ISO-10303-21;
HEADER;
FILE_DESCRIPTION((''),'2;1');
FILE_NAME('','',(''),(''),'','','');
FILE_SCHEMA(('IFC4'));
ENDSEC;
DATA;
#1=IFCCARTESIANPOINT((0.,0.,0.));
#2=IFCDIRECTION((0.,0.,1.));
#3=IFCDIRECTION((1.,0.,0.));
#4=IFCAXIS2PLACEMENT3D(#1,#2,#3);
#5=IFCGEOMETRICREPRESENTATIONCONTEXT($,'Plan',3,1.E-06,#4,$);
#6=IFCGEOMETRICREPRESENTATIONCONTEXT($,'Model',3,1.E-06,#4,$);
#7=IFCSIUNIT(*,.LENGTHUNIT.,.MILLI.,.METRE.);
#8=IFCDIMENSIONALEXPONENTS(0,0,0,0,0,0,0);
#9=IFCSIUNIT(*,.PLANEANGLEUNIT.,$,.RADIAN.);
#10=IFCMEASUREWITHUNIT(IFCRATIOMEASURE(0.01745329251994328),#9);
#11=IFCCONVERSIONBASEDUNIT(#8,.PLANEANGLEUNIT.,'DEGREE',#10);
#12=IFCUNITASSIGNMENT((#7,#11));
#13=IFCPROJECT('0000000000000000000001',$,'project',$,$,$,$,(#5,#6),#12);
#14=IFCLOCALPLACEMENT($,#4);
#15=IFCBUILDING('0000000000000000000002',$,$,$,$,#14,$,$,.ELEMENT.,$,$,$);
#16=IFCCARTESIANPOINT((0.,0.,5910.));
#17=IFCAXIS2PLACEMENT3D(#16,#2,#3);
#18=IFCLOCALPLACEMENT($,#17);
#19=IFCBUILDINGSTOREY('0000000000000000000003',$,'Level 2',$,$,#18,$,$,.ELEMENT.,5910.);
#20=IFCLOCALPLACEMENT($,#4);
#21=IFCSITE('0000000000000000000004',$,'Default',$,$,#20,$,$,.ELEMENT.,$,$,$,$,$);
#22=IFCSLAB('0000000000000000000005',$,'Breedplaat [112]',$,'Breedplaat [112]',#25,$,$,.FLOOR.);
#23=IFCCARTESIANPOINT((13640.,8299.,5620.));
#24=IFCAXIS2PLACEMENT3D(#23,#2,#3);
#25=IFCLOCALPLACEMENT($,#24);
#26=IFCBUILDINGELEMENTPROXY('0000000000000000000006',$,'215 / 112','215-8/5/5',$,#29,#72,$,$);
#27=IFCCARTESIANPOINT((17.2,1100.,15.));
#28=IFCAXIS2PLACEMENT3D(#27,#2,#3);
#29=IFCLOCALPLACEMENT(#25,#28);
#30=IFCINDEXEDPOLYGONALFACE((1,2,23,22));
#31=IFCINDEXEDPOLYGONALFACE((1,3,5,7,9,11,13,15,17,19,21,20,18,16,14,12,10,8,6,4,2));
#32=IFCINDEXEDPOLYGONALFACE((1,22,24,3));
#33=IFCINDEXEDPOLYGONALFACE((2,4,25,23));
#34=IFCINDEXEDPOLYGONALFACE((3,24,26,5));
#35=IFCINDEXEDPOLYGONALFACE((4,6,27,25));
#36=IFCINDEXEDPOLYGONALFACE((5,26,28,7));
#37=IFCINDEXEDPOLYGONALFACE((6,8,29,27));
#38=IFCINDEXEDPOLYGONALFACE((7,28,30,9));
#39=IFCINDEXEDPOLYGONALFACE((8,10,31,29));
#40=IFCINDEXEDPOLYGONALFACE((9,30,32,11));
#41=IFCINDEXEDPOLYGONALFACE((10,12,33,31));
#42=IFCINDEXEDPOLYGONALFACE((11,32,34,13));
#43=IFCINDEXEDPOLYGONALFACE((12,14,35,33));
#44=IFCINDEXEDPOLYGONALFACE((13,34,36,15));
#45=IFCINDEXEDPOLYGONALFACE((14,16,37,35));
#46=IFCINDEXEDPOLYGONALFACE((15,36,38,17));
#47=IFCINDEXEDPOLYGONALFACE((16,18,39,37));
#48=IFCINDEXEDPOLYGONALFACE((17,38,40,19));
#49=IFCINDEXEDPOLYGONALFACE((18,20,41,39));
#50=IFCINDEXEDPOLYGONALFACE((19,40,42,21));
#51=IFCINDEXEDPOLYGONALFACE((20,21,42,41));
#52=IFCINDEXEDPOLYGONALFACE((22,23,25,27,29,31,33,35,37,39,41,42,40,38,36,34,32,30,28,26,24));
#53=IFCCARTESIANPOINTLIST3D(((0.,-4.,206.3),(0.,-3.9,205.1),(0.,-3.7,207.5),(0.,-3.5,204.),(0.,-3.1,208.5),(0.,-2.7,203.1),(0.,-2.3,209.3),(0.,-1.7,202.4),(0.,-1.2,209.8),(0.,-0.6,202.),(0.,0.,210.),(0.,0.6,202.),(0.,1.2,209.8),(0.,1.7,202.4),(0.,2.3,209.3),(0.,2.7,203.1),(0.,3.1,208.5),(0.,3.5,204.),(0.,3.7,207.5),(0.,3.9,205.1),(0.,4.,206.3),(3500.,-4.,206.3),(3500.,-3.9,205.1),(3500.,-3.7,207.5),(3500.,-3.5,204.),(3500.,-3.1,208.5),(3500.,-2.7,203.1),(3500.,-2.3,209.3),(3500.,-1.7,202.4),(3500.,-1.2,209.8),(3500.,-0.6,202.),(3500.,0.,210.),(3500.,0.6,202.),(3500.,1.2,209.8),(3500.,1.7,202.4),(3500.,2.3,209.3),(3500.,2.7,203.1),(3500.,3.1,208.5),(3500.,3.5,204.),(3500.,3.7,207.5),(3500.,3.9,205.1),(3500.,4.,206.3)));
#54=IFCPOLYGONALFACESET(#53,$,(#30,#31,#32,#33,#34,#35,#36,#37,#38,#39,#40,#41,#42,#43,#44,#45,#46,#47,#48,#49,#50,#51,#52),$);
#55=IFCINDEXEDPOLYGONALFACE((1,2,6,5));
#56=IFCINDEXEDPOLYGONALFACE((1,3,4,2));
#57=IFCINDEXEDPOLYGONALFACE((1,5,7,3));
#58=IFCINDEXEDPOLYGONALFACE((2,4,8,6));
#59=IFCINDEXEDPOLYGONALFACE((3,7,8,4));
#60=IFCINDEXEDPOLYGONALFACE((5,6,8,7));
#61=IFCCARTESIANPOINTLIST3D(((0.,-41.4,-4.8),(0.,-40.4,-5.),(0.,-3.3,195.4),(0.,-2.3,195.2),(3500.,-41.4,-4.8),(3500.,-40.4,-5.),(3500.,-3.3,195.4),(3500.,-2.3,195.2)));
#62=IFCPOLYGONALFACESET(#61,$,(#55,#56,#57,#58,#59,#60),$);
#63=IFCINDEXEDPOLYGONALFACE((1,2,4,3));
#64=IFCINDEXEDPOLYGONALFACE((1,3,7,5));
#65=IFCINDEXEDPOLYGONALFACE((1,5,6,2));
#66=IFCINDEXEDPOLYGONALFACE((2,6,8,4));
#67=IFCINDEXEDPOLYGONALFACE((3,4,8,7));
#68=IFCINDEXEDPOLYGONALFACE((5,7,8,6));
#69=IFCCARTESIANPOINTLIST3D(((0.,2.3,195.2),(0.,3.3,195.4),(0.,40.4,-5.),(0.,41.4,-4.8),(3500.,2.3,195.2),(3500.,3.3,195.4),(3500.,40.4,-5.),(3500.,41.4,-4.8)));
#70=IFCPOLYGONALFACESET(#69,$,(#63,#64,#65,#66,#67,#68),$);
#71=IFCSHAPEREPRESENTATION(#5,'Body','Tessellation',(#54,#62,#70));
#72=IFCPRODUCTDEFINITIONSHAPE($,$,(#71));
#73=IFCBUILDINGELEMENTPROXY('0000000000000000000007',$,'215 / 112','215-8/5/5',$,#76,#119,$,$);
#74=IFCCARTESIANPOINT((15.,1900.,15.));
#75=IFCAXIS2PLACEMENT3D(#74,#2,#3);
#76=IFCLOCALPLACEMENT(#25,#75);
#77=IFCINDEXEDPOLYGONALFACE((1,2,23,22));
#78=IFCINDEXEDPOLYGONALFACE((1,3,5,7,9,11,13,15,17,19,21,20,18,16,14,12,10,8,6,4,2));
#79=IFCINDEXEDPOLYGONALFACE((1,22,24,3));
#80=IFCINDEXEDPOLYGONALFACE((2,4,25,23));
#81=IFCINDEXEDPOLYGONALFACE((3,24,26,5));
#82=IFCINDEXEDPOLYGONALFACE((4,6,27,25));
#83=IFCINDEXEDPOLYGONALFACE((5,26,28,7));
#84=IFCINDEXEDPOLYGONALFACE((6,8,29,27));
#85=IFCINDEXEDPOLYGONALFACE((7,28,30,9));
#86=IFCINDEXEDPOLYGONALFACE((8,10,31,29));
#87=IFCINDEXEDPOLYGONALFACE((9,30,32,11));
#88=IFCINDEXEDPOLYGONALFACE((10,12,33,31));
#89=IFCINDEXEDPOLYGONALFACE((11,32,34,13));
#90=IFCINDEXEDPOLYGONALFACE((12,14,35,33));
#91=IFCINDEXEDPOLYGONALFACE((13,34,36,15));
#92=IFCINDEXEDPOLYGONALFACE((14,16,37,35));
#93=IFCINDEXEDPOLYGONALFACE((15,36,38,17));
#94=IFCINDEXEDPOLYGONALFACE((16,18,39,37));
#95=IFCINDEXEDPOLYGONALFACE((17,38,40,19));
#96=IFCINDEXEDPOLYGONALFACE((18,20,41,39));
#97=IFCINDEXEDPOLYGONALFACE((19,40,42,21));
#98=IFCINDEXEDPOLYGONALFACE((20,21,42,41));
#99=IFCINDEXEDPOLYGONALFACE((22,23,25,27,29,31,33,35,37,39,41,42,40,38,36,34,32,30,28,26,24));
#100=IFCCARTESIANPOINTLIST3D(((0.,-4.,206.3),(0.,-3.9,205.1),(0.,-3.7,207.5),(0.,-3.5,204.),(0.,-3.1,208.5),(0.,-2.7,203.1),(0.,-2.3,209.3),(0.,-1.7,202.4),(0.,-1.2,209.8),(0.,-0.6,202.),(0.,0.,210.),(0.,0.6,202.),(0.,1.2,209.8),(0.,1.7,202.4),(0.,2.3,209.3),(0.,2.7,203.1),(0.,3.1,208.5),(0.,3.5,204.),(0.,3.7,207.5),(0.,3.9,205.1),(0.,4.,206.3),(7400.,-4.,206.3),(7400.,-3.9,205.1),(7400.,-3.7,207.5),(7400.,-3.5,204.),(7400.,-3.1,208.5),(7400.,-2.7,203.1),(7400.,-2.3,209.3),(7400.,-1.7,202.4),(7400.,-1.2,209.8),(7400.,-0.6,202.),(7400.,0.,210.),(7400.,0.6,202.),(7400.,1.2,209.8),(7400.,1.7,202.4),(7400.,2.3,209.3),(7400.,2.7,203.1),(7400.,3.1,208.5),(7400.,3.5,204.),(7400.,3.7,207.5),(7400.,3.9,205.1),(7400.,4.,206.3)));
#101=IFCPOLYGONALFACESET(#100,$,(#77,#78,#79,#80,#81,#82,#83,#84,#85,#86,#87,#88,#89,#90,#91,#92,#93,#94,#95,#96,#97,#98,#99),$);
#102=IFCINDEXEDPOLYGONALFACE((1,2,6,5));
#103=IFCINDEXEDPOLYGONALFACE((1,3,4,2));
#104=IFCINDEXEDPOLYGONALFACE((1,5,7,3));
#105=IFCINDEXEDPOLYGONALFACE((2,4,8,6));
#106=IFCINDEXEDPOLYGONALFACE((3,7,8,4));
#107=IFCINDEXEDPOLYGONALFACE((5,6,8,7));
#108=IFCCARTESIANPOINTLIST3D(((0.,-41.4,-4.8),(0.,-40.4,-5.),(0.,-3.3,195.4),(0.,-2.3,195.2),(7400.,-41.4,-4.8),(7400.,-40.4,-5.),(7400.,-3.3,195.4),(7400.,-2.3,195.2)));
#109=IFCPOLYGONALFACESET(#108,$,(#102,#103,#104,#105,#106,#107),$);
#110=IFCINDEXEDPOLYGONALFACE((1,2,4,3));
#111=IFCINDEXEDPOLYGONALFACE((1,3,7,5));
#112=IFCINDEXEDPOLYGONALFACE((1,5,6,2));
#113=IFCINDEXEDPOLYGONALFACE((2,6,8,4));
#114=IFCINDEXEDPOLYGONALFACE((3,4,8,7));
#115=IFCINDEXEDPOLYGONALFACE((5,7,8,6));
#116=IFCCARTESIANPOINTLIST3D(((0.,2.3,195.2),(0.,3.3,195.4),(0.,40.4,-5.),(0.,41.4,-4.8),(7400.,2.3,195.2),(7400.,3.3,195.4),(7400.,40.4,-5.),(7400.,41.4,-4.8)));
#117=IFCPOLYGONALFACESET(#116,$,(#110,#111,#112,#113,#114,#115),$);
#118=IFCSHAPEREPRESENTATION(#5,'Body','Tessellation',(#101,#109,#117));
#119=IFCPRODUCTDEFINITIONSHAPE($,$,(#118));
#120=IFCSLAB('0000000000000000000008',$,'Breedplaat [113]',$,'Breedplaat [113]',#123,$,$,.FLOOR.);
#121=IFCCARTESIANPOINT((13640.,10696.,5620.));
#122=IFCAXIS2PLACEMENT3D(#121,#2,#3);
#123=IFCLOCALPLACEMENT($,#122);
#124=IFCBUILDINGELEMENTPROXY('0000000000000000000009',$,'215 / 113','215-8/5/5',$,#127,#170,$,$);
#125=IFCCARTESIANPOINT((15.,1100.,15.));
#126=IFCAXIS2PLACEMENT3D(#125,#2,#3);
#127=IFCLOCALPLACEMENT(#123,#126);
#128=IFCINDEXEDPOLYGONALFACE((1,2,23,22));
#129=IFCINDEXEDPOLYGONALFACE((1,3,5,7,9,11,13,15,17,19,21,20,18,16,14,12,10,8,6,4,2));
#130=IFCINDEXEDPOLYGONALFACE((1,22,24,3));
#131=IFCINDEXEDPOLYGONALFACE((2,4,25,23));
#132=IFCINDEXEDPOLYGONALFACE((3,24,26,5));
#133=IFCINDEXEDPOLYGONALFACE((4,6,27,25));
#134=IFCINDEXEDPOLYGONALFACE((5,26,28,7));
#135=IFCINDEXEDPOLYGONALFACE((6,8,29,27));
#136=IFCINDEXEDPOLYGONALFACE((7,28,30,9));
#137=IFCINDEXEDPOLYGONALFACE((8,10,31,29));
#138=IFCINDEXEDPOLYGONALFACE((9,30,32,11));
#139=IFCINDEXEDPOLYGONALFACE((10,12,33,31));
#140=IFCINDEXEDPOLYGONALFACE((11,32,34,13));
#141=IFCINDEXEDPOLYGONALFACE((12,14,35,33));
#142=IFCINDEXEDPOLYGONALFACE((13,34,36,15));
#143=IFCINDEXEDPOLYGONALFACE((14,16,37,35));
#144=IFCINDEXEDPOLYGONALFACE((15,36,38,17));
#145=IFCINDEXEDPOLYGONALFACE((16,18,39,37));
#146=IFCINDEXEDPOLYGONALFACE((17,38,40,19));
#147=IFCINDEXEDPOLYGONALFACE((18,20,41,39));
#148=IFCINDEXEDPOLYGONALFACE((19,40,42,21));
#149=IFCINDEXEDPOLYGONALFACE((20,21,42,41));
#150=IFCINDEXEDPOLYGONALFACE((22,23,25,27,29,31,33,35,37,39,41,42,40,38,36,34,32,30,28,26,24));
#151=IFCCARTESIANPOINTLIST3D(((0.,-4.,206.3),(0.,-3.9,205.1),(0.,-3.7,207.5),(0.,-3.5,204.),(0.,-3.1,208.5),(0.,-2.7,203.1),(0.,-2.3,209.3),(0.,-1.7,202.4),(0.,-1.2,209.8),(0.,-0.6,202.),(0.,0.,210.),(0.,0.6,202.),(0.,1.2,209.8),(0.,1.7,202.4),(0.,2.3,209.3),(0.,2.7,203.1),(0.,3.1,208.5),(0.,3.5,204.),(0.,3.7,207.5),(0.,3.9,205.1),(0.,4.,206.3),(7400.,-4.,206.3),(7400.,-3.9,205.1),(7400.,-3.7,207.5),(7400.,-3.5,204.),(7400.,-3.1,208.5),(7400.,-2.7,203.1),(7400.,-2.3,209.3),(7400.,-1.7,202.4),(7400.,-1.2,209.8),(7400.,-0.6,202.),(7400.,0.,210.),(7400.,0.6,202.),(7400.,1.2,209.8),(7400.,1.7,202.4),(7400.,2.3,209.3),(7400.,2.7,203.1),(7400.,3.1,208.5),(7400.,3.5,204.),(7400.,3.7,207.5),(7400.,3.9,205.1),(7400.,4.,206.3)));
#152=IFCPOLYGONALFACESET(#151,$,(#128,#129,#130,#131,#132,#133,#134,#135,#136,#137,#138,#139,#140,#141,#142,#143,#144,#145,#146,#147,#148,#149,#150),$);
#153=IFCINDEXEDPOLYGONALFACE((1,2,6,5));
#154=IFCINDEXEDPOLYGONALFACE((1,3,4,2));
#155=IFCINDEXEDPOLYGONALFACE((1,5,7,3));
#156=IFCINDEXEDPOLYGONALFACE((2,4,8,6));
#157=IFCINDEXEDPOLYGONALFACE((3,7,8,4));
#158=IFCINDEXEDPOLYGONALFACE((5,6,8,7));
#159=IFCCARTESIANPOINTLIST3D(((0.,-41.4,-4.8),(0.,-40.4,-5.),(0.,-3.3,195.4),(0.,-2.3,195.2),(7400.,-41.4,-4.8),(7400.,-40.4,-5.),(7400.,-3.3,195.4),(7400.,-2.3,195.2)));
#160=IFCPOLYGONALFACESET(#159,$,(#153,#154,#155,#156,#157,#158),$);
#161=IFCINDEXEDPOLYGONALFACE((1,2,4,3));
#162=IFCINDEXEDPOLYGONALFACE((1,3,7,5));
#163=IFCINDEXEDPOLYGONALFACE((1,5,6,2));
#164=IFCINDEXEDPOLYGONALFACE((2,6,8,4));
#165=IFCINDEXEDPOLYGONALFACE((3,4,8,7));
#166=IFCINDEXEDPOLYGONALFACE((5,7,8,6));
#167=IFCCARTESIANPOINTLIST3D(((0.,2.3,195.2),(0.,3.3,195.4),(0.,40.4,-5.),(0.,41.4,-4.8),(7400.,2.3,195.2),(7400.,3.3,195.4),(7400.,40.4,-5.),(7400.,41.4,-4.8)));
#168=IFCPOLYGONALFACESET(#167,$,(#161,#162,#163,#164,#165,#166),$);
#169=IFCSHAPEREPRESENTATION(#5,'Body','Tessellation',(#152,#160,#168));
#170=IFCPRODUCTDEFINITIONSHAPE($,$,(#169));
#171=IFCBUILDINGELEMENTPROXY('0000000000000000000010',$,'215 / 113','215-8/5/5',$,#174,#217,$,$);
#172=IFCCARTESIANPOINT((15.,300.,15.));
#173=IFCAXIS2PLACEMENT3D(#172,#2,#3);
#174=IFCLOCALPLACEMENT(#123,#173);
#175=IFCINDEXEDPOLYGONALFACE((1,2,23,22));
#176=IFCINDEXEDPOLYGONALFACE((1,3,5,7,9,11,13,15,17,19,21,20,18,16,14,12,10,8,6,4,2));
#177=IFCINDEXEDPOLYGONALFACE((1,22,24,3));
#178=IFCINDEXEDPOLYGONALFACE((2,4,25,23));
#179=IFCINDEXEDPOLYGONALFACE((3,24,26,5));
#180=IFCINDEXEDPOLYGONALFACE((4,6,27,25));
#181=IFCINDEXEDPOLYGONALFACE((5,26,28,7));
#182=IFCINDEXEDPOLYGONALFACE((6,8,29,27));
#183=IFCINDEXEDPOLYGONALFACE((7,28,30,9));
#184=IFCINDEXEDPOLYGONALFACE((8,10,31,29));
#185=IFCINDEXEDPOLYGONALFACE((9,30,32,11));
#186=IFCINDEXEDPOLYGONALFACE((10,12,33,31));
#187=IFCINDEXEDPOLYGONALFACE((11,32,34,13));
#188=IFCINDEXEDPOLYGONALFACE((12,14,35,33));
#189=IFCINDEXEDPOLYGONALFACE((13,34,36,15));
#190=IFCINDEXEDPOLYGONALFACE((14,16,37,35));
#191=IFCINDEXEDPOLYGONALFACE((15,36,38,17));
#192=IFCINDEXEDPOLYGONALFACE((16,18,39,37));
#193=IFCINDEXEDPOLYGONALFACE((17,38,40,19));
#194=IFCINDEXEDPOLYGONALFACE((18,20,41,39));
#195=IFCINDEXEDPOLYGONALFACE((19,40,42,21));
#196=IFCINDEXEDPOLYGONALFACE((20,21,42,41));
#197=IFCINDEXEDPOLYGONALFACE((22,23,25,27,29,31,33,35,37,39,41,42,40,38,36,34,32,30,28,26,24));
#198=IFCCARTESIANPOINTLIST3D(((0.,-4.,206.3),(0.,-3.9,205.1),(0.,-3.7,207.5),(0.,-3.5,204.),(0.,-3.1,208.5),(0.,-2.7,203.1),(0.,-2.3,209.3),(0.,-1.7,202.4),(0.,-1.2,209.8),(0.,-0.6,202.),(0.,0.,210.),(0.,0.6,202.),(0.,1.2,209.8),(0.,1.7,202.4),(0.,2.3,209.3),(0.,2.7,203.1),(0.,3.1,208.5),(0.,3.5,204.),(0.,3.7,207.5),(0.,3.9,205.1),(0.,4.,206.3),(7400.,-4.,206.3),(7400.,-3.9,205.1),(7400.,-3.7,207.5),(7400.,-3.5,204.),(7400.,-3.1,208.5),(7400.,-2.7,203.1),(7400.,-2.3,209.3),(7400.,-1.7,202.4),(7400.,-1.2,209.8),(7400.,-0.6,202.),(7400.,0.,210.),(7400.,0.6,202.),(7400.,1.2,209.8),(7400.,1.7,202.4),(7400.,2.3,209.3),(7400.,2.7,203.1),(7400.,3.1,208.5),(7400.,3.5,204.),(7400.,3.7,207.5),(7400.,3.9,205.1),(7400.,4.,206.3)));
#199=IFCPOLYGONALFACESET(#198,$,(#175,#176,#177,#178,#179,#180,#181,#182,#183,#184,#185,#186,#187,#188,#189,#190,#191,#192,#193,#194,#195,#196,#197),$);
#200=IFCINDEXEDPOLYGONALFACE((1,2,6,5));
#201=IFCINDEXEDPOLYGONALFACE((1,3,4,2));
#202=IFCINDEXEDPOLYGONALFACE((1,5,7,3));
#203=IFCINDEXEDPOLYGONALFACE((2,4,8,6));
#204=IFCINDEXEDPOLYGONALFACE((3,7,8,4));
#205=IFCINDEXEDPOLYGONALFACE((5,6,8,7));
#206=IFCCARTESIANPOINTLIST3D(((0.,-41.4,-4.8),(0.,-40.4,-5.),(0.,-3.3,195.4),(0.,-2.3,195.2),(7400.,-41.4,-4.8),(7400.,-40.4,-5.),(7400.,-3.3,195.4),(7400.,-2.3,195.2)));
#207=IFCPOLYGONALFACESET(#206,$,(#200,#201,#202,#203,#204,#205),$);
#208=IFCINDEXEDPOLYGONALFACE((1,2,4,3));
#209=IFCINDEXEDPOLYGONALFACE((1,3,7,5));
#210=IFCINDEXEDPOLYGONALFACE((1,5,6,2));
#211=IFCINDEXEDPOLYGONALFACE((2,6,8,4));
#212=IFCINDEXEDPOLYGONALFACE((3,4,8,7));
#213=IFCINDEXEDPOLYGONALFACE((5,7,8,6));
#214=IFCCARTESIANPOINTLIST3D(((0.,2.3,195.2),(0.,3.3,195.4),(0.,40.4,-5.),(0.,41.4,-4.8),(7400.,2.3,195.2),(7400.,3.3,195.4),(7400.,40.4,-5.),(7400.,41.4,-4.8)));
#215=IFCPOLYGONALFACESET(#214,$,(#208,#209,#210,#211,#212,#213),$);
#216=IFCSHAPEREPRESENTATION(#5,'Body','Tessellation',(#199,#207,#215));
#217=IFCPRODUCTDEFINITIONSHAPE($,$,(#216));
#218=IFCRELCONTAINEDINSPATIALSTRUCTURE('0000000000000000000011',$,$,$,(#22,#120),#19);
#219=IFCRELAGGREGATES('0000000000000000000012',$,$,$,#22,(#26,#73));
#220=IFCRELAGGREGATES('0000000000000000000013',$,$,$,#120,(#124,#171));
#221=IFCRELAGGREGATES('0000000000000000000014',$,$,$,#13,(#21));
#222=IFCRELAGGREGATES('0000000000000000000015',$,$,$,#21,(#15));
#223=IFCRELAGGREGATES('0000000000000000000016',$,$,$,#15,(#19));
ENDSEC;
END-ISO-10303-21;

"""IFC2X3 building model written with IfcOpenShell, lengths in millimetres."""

from ifc_helpers import new_model, entity, si_unit, converted_unit, frame, origin_with_axes, origin_2d_with_axis, place, context, project, spatial, rectangle, circle, extrude, element, aggregate, save


model = new_model("IFC2X3")

# Units and contexts
plan_context = context("Plan", 3, precision=1e-06, world=origin_with_axes())
model_context = context("Model", 3, precision=1e-06, world=origin_with_axes())
ifc_project = project(units=[si_unit("LENGTHUNIT", "METRE", prefix="MILLI"), converted_unit("PLANEANGLEUNIT", "DEGREE", entity("IfcRatioMeasure", 0.01745329251994328), si_unit("PLANEANGLEUNIT", "RADIAN"), dimensions=[0, 0, 0, 0, 0, 0, 0])], contexts=[plan_context, model_context])

# Site, building, storey
site_placement = place(None, origin_with_axes())
site = spatial("IfcSite", under=ifc_project, at=site_placement, Name="Default", CompositionType="ELEMENT")
building_placement = place(None, origin_with_axes())
building = spatial("IfcBuilding", under=site, at=building_placement, CompositionType="ELEMENT")
storey_placement = place(None, frame((0.0, 0.0, 5910.0), z_axis=(0.0, 0.0, 1.0), x_axis=(1.0, 0.0, 0.0)))
storey = spatial("IfcBuildingStorey", under=building, at=storey_placement, Name="Level 2", CompositionType="ELEMENT", Elevation=5910.0)

# Slab, building element proxies
slab_1_placement = place(None, frame((13640.0, 8299.0, 5620.0), z_axis=(0.0, 0.0, 1.0), x_axis=(1.0, 0.0, 0.0)))
slab_1 = element("IfcSlab", 1, at=slab_1_placement, inside=storey, Name="Breedplaat [112]", ObjectType="Breedplaat [112]", PredefinedType="FLOOR")
proxy_1_placement = place(slab_1_placement, frame((17.2, 1100.0, 15.0), z_axis=(0.0, 0.0, 1.0), x_axis=(1.0, 0.0, 0.0)))
proxy_1 = element("IfcBuildingElementProxy", 2, at=proxy_1_placement, Name="215 / 112", Description="215-8/5/5", context=plan_context, shape_type="SweptSolid", body=[
    extrude(circle(Radius=4.0, at=origin_2d_with_axis()), frame((0.0, 0.0, 206.0), z_axis=(1.0, 0.0, 0.0), x_axis=(0.0, 0.0, 1.0)), (0.0, 0.0, 1.0), 3500.0),
    extrude(rectangle(XDim=203.8, YDim=1.0, at=origin_2d_with_axis()), frame((0.0, -21.9, 95.2), z_axis=(1.0, 0.0, 0.0), x_axis=(0.0, 0.187112, 0.982339)), (0.0, 0.0, 1.0), 3500.0),
    extrude(rectangle(XDim=203.8, YDim=1.0, at=origin_2d_with_axis()), frame((0.0, 21.9, 95.2), z_axis=(1.0, 0.0, 0.0), x_axis=(0.0, -0.187112, 0.982339)), (0.0, 0.0, 1.0), 3500.0),
])
proxy_2_placement = place(slab_1_placement, frame((15.0, 1900.0, 15.0), z_axis=(0.0, 0.0, 1.0), x_axis=(1.0, 0.0, 0.0)))
proxy_2 = element("IfcBuildingElementProxy", 3, at=proxy_2_placement, Name="215 / 112", Description="215-8/5/5", context=plan_context, shape_type="SweptSolid", body=[
    extrude(circle(Radius=4.0, at=origin_2d_with_axis()), frame((0.0, 0.0, 206.0), z_axis=(1.0, 0.0, 0.0), x_axis=(0.0, 0.0, 1.0)), (0.0, 0.0, 1.0), 7400.0),
    extrude(rectangle(XDim=203.8, YDim=1.0, at=origin_2d_with_axis()), frame((0.0, -21.9, 95.2), z_axis=(1.0, 0.0, 0.0), x_axis=(0.0, 0.187112, 0.982339)), (0.0, 0.0, 1.0), 7400.0),
    extrude(rectangle(XDim=203.8, YDim=1.0, at=origin_2d_with_axis()), frame((0.0, 21.9, 95.2), z_axis=(1.0, 0.0, 0.0), x_axis=(0.0, -0.187112, 0.982339)), (0.0, 0.0, 1.0), 7400.0),
])
aggregate(slab_1, [proxy_1, proxy_2])

# Slab, building element proxies
slab_2_placement = place(None, frame((13640.0, 10696.0, 5620.0), z_axis=(0.0, 0.0, 1.0), x_axis=(1.0, 0.0, 0.0)))
slab_2 = element("IfcSlab", 4, at=slab_2_placement, inside=storey, Name="Breedplaat [113]", ObjectType="Breedplaat [113]", PredefinedType="FLOOR")
proxy_3_placement = place(slab_2_placement, frame((15.0, 1100.0, 15.0), z_axis=(0.0, 0.0, 1.0), x_axis=(1.0, 0.0, 0.0)))
proxy_3 = element("IfcBuildingElementProxy", 5, at=proxy_3_placement, Name="215 / 113", Description="215-8/5/5", context=plan_context, shape_type="SweptSolid", body=[
    extrude(circle(Radius=4.0, at=origin_2d_with_axis()), frame((0.0, 0.0, 206.0), z_axis=(1.0, 0.0, 0.0), x_axis=(0.0, 0.0, 1.0)), (0.0, 0.0, 1.0), 7400.0),
    extrude(rectangle(XDim=203.8, YDim=1.0, at=origin_2d_with_axis()), frame((0.0, -21.9, 95.2), z_axis=(1.0, 0.0, 0.0), x_axis=(0.0, 0.187112, 0.982339)), (0.0, 0.0, 1.0), 7400.0),
    extrude(rectangle(XDim=203.8, YDim=1.0, at=origin_2d_with_axis()), frame((0.0, 21.9, 95.2), z_axis=(1.0, 0.0, 0.0), x_axis=(0.0, -0.187112, 0.982339)), (0.0, 0.0, 1.0), 7400.0),
])
proxy_4_placement = place(slab_2_placement, frame((15.0, 300.0, 15.0), z_axis=(0.0, 0.0, 1.0), x_axis=(1.0, 0.0, 0.0)))
proxy_4 = element("IfcBuildingElementProxy", 6, at=proxy_4_placement, Name="215 / 113", Description="215-8/5/5", context=plan_context, shape_type="SweptSolid", body=[
    extrude(circle(Radius=4.0, at=origin_2d_with_axis()), frame((0.0, 0.0, 206.0), z_axis=(1.0, 0.0, 0.0), x_axis=(0.0, 0.0, 1.0)), (0.0, 0.0, 1.0), 7400.0),
    extrude(rectangle(XDim=203.8, YDim=1.0, at=origin_2d_with_axis()), frame((0.0, -21.9, 95.2), z_axis=(1.0, 0.0, 0.0), x_axis=(0.0, 0.187112, 0.982339)), (0.0, 0.0, 1.0), 7400.0),
    extrude(rectangle(XDim=203.8, YDim=1.0, at=origin_2d_with_axis()), frame((0.0, 21.9, 95.2), z_axis=(1.0, 0.0, 0.0), x_axis=(0.0, -0.187112, 0.982339)), (0.0, 0.0, 1.0), 7400.0),
])
aggregate(slab_2, [proxy_3, proxy_4])

save(model, "model.ifc")
